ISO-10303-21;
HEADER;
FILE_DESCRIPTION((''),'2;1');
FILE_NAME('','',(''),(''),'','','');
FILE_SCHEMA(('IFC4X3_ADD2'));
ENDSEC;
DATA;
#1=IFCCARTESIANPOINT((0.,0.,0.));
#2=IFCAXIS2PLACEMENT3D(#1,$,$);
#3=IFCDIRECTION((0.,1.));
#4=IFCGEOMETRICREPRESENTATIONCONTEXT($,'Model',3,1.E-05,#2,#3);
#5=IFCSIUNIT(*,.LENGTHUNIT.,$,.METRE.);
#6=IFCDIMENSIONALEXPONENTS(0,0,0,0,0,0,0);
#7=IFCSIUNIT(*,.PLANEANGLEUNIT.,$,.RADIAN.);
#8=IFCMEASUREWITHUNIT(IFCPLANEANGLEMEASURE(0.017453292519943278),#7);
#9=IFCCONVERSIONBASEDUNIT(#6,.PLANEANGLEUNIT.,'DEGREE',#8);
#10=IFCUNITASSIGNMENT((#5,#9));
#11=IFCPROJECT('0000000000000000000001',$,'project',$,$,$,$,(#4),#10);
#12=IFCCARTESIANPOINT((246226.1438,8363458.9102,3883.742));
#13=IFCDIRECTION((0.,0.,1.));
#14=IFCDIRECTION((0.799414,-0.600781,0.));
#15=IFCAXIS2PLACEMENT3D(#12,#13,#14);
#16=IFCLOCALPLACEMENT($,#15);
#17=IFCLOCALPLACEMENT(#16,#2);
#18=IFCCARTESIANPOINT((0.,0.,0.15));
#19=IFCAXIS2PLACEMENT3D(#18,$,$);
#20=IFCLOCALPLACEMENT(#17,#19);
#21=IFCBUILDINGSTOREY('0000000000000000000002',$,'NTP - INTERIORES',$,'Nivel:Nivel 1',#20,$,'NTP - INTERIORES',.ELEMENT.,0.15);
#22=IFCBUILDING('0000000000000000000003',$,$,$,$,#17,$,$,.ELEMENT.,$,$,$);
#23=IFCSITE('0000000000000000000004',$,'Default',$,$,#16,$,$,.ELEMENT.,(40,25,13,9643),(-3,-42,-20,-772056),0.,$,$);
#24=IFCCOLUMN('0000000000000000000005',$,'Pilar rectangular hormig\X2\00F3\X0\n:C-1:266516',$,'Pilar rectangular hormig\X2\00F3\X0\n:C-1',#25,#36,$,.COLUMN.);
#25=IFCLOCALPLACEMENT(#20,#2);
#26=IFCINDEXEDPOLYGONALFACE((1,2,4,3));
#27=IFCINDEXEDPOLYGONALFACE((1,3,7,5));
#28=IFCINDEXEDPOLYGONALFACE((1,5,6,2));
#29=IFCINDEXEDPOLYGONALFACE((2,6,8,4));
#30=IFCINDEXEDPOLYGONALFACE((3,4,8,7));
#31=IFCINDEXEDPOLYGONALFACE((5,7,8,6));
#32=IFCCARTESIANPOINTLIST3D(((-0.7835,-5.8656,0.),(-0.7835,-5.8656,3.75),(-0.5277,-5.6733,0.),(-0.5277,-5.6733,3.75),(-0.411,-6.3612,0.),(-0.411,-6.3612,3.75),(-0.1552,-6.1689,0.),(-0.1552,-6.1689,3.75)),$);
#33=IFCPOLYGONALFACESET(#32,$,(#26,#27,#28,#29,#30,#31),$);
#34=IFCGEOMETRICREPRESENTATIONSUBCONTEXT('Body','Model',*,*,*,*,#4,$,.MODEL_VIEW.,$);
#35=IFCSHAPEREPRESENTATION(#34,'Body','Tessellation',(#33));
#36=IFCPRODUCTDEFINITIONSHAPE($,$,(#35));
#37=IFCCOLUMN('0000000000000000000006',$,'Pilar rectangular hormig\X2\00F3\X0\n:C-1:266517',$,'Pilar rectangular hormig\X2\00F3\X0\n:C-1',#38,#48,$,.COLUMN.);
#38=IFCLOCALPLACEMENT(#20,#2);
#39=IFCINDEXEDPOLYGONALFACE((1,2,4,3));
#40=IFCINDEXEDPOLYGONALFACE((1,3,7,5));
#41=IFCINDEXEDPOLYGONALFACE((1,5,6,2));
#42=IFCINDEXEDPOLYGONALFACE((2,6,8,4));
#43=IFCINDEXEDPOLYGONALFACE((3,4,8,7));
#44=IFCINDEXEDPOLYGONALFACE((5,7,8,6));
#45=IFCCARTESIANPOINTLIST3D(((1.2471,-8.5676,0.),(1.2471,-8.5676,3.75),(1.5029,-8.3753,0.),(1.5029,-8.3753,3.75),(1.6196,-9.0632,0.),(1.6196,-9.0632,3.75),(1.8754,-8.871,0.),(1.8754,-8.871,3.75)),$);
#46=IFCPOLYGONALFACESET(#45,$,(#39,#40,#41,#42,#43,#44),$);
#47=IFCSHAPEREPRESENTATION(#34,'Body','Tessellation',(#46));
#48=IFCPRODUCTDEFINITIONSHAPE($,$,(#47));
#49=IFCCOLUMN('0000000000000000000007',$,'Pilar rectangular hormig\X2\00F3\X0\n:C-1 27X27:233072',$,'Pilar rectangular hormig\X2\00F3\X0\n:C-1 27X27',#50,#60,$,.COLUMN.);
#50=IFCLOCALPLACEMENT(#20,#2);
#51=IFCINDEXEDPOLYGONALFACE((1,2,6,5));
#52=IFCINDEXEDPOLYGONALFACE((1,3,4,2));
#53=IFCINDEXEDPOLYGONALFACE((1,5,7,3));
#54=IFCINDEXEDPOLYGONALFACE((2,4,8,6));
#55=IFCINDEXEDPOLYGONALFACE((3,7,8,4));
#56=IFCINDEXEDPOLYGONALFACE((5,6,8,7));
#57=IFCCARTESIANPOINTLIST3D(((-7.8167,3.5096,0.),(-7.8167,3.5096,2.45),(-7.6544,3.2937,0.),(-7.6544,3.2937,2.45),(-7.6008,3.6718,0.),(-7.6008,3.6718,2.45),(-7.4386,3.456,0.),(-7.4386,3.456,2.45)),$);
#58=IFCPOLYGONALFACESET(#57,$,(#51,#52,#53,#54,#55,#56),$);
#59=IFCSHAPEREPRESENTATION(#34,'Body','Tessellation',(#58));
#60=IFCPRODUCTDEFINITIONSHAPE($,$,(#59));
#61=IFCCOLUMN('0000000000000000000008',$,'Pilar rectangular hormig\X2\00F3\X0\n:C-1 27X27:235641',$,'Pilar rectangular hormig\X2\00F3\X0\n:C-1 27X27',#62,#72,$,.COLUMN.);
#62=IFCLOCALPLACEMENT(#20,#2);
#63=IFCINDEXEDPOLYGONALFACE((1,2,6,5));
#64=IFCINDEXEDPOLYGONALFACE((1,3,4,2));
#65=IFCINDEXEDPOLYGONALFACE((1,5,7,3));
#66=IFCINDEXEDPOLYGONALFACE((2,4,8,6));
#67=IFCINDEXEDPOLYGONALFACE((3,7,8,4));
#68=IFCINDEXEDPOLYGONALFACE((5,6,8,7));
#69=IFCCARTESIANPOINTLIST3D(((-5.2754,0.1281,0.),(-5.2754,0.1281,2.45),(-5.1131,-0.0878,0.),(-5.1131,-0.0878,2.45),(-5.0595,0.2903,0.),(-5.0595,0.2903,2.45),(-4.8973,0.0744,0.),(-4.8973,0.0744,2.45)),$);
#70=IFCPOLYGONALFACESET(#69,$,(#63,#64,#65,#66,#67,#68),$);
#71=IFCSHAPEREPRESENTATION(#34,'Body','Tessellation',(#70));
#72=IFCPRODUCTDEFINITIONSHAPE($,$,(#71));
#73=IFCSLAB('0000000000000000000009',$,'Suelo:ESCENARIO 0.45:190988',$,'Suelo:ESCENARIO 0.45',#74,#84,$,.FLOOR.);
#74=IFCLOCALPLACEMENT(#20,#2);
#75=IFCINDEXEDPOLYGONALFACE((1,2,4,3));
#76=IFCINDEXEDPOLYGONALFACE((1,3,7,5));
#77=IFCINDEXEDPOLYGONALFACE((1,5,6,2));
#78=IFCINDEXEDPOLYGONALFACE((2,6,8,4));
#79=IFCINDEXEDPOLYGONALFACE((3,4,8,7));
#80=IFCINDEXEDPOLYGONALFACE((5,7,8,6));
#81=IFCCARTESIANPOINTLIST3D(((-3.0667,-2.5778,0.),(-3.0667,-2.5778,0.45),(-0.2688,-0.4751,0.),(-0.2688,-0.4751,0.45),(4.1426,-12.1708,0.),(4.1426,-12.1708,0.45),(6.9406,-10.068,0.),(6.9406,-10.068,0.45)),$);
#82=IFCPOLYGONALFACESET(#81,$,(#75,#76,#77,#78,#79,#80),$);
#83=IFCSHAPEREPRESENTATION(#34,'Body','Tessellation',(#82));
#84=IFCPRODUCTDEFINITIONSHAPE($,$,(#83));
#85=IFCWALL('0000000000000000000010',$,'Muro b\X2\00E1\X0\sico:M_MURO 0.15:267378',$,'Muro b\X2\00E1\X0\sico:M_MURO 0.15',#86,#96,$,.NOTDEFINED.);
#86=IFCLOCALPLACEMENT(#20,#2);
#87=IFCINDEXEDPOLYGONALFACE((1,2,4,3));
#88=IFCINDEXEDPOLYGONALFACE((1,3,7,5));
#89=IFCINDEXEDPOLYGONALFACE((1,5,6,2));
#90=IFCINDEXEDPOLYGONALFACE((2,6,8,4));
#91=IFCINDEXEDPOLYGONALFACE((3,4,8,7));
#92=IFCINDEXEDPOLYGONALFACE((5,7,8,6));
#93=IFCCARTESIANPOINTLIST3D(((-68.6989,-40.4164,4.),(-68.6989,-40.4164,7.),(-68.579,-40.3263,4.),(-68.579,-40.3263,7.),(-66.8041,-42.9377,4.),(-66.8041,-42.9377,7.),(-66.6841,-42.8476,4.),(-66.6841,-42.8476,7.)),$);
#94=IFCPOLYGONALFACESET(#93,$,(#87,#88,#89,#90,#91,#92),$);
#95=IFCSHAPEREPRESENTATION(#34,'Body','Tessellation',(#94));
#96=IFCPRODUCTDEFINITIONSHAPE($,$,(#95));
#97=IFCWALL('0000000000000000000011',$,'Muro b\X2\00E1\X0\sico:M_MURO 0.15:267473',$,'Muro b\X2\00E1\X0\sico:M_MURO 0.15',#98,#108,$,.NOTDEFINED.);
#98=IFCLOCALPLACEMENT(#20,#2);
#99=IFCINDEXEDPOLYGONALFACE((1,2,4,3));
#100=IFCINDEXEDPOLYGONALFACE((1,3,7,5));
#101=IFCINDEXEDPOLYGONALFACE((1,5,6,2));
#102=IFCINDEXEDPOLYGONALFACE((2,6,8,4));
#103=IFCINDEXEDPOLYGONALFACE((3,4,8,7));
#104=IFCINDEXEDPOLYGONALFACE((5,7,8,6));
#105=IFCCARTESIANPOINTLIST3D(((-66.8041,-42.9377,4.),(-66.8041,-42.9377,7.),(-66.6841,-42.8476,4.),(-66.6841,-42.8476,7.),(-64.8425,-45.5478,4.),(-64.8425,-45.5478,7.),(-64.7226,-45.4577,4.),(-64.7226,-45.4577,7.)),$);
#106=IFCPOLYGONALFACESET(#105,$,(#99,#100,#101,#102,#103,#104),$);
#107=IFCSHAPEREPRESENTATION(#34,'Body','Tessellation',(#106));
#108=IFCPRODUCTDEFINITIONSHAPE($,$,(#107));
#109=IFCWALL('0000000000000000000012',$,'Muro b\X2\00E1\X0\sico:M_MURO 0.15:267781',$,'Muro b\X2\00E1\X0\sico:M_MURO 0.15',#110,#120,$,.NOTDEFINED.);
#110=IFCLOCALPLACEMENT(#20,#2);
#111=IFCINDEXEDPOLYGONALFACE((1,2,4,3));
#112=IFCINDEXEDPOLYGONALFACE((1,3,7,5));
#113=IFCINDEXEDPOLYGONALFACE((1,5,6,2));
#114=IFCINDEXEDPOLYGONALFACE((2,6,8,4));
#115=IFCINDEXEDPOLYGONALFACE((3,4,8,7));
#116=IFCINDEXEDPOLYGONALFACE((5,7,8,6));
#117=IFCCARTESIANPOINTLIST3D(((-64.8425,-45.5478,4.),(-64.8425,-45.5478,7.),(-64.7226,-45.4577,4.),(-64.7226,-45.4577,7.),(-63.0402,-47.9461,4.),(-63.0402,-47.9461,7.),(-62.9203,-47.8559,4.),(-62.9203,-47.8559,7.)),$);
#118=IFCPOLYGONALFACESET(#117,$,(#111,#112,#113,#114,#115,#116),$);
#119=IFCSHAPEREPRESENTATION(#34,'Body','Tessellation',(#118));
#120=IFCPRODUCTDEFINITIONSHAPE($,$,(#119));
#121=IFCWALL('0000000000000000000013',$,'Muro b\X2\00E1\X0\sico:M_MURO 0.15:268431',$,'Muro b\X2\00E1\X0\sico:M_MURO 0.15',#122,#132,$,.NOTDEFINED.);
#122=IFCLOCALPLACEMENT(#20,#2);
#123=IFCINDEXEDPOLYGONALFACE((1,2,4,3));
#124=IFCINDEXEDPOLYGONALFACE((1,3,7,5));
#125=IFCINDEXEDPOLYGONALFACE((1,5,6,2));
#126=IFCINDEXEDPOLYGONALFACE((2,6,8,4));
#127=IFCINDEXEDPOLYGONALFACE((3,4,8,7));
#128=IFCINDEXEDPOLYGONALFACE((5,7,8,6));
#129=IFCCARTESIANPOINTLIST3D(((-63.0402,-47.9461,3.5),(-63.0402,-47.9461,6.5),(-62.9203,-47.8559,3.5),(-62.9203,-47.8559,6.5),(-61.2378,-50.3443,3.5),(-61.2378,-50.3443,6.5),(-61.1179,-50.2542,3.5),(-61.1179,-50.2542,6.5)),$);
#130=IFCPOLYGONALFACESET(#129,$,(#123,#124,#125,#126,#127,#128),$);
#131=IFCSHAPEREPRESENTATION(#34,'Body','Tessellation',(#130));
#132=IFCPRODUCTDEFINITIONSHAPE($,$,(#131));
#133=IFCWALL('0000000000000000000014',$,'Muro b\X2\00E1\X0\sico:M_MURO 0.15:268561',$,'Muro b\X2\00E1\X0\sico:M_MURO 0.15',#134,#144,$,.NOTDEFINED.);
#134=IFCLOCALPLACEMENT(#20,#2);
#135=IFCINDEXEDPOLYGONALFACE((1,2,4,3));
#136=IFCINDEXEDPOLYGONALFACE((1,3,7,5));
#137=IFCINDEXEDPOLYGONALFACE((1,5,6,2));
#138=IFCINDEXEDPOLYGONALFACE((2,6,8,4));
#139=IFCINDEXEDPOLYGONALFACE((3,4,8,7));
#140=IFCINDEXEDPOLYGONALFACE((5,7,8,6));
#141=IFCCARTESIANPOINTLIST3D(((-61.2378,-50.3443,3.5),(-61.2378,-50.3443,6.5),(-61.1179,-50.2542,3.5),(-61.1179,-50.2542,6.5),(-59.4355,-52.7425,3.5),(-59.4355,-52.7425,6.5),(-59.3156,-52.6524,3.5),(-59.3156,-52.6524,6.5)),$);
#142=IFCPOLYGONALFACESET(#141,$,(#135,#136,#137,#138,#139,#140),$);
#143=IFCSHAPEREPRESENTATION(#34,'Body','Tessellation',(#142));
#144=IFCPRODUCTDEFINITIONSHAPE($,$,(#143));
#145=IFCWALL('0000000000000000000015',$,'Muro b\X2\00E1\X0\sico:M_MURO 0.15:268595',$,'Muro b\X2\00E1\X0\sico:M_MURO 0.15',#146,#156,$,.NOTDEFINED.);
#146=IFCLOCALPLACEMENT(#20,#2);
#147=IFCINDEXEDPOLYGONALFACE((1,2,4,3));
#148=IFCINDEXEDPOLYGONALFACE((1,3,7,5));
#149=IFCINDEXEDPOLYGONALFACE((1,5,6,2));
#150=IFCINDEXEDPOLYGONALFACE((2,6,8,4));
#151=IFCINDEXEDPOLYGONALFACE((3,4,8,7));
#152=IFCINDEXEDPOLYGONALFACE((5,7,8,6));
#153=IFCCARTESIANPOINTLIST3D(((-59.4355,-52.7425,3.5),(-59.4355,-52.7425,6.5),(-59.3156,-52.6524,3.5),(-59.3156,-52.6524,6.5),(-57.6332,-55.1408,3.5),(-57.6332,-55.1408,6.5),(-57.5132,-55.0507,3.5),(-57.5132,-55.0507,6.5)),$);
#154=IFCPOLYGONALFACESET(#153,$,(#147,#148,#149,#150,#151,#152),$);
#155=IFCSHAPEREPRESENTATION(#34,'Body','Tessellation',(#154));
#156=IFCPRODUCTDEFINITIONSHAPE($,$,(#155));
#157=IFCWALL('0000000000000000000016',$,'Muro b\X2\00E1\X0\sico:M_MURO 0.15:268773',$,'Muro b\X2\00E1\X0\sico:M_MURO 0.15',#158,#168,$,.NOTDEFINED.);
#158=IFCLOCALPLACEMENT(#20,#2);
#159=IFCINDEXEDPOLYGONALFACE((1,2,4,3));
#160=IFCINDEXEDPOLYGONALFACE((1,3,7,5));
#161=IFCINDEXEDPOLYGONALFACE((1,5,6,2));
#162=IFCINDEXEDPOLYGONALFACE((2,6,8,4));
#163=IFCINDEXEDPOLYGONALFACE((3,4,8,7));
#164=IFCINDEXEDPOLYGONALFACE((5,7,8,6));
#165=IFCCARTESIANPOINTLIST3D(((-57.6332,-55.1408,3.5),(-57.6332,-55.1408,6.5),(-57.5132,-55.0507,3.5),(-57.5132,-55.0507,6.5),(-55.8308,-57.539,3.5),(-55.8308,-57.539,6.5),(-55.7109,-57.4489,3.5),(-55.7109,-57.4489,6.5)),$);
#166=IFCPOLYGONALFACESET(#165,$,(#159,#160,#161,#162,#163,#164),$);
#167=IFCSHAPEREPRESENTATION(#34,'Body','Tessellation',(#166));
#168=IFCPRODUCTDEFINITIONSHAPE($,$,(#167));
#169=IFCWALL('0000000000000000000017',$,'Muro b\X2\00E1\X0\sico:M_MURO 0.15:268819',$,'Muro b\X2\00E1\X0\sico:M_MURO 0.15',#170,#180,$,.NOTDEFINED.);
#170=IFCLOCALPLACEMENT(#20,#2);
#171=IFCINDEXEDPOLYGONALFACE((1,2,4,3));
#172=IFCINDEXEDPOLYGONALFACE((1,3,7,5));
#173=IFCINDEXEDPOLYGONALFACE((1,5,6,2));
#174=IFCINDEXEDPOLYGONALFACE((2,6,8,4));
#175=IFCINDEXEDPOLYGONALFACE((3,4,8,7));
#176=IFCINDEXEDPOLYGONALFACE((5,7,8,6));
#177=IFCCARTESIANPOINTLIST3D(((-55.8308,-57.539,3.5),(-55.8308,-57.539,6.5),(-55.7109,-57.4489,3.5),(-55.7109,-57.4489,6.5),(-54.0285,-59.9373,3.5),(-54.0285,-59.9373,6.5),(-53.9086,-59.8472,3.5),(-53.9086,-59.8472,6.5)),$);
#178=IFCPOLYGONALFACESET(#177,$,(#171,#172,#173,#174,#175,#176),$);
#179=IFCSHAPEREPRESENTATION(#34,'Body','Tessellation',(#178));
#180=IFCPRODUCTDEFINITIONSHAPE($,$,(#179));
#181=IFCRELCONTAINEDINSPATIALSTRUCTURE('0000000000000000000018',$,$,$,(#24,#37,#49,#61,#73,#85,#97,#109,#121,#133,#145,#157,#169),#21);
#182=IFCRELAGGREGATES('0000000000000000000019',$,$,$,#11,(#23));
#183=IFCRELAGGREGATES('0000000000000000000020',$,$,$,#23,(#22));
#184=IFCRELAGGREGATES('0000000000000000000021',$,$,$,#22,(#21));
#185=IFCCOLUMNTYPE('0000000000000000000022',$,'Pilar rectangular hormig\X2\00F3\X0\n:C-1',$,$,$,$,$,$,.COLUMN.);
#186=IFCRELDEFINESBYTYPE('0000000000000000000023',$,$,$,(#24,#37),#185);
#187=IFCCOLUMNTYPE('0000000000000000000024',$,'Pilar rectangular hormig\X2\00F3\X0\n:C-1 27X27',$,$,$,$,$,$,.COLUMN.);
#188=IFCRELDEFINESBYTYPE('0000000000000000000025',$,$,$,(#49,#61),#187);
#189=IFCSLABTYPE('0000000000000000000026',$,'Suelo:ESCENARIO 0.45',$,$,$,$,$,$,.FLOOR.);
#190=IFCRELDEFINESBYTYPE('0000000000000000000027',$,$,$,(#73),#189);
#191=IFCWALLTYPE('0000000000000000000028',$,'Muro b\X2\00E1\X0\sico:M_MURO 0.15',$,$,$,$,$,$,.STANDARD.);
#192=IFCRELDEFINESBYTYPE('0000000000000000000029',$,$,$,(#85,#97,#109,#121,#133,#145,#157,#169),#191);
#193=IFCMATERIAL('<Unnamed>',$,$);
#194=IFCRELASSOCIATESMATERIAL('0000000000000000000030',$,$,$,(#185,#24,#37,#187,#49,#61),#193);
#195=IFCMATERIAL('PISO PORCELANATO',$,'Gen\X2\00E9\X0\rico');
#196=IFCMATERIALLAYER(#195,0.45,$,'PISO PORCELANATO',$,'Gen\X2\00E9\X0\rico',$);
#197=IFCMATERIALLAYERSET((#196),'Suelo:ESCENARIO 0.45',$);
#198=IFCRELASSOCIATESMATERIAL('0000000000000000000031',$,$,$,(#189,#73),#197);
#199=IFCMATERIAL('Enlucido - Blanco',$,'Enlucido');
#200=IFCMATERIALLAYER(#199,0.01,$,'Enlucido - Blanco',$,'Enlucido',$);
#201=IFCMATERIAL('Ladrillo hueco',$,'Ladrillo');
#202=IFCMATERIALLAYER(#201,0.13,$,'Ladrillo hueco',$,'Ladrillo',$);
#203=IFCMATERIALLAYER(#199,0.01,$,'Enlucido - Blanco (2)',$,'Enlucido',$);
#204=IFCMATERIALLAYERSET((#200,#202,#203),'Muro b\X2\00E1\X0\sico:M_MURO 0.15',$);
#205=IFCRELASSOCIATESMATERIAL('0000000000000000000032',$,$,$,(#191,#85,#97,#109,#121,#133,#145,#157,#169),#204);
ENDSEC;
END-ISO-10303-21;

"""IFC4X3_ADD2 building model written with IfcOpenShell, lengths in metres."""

from ifc_helpers import new_model, entity, si_unit, converted_unit, direction, frame, frame_2d, origin, origin_2d_with_axis, place, context, subcontext, project, spatial, rectangle, extrude, source, transform, mapped, material, layer, layer_set, layer_usage, material_profile, profile_set, profile_usage, type_object, type_shapes, element, save


model = new_model("IFC4X3_ADD2")

# Units and contexts
model_context = context("Model", 3, precision=1e-05, world=origin(), true_north=direction((0.0, 1.0)))
body_context = subcontext(model_context, "Body", "Model", "MODEL_VIEW")
ifc_project = project(units=[si_unit("LENGTHUNIT", "METRE"), converted_unit("PLANEANGLEUNIT", "DEGREE", entity("IfcPlaneAngleMeasure", 0.017453292519943278), si_unit("PLANEANGLEUNIT", "RADIAN"), dimensions=[0, 0, 0, 0, 0, 0, 0])], contexts=[model_context])

# Site, building, storey
site_placement = place(None, frame((246226.1438, 8363458.9102, 3883.742), z_axis=(0.0, 0.0, 1.0), x_axis=(0.799414, -0.600781, 0.0)))
site = spatial("IfcSite", under=ifc_project, at=site_placement, Name="Default", CompositionType="ELEMENT", RefLatitude=(40, 25, 13, 9643), RefLongitude=(-3, -42, -20, -772056), RefElevation=0.0)
building_placement = place(site_placement, origin())
building = spatial("IfcBuilding", under=site, at=building_placement, CompositionType="ELEMENT")
storey_placement = place(building_placement, frame((0.0, 0.0, 0.15)))
storey = spatial("IfcBuildingStorey", under=building, at=storey_placement, Name="NTP - INTERIORES", ObjectType="Nivel:Nivel 1", LongName="NTP - INTERIORES", CompositionType="ELEMENT", Elevation=0.15)

# Columns
ifc_material_1 = material(Name="<Unnamed>")
ifc_material_profile_1 = material_profile(ifc_material_1, rectangle(XDim=0.32, YDim=0.62, at=origin_2d_with_axis()), Name="C-1")
ifc_profile_set_1 = profile_set([ifc_material_profile_1], Name="C-1")
ifc_profile_usage_1 = profile_usage(ifc_profile_set_1)
column_type_1 = type_object("IfcColumnType", Name="Pilar rectangular hormigón:C-1", PredefinedType="COLUMN", material=ifc_profile_set_1)
shared_shape_1 = source(origin(), body_context, "Body", "SweptSolid", [
    extrude(rectangle(XDim=0.32, YDim=0.62, at=origin_2d_with_axis()), frame((0.16, 0.31, 0.0), z_axis=(0.0, 0.0, 1.0), x_axis=(-1.0, 0.0, 0.0)), (0.0, 0.0, 1.0), 3.75),
])
type_shapes(column_type_1, [shared_shape_1])
for number, where, z_axis, x_axis, name in (
    (1, (-0.411, -6.3612, 0.0), (0.0, 0.0, 1.0), (0.799414, 0.60078, 0.0), "Pilar rectangular hormigón:C-1:266516"),
    (2, (1.6196, -9.0632, 0.0), (0.0, 0.0, 1.0), (0.799414, 0.60078, 0.0), "Pilar rectangular hormigón:C-1:266517"),
):
    element("IfcColumn", number, at=place(storey_placement, frame(where, z_axis=z_axis, x_axis=x_axis)), inside=storey, type_object=column_type_1, material=ifc_profile_usage_1, Name=name, ObjectType="Pilar rectangular hormigón:C-1", PredefinedType="COLUMN", context=body_context, shape_type="MappedRepresentation", body=[
        mapped(shared_shape_1, transform((0.0, 0.0, 0.0), scale=1.0)),
    ])
ifc_material_profile_2 = material_profile(ifc_material_1, rectangle(XDim=0.27, YDim=0.27, at=origin_2d_with_axis()), Name="C-1 27X27")
ifc_profile_set_2 = profile_set([ifc_material_profile_2], Name="C-1 27X27")
ifc_profile_usage_2 = profile_usage(ifc_profile_set_2)
column_type_2 = type_object("IfcColumnType", Name="Pilar rectangular hormigón:C-1 27X27", PredefinedType="COLUMN", material=ifc_profile_set_2)
shared_shape_2 = source(origin(), body_context, "Body", "SweptSolid", [
    extrude(rectangle(XDim=0.27, YDim=0.27, at=origin_2d_with_axis()), frame((0.135, 0.135, 0.0), z_axis=(0.0, 0.0, 1.0), x_axis=(-1.0, 0.0, 0.0)), (0.0, 0.0, 1.0), 2.45),
])
type_shapes(column_type_2, [shared_shape_2])
for number, where, z_axis, x_axis, name in (
    (3, (-7.6544, 3.2937, 0.0), (0.0, 0.0, 1.0), (0.799414, 0.60078, 0.0), "Pilar rectangular hormigón:C-1 27X27:233072"),
    (4, (-5.1131, -0.0878, 0.0), (0.0, 0.0, 1.0), (0.799414, 0.60078, 0.0), "Pilar rectangular hormigón:C-1 27X27:235641"),
):
    element("IfcColumn", number, at=place(storey_placement, frame(where, z_axis=z_axis, x_axis=x_axis)), inside=storey, type_object=column_type_2, material=ifc_profile_usage_2, Name=name, ObjectType="Pilar rectangular hormigón:C-1 27X27", PredefinedType="COLUMN", context=body_context, shape_type="MappedRepresentation", body=[
        mapped(shared_shape_2, transform((0.0, 0.0, 0.0), scale=1.0)),
    ])

# Slab
ifc_material_2 = material(Name="PISO PORCELANATO", Category="Genérico")
ifc_layer_1 = layer(ifc_material_2, 0.45, Name="PISO PORCELANATO", Category="Genérico")
ifc_layer_set_1 = layer_set([ifc_layer_1], Name="Suelo:ESCENARIO 0.45")
ifc_layer_usage_1 = layer_usage(ifc_layer_set_1, "AXIS3", "POSITIVE", 0.0)
slab_type_1 = type_object("IfcSlabType", Name="Suelo:ESCENARIO 0.45", PredefinedType="FLOOR", material=ifc_layer_set_1)
slab_1_placement = place(storey_placement, origin())
element("IfcSlab", 5, at=slab_1_placement, inside=storey, type_object=slab_type_1, material=ifc_layer_usage_1, Name="Suelo:ESCENARIO 0.45:190988", ObjectType="Suelo:ESCENARIO 0.45", PredefinedType="FLOOR", context=body_context, shape_type="SweptSolid", body=[
    extrude(rectangle(XDim=3.5, YDim=12.0, at=frame_2d((0.0, 0.0), x_axis=(1.0, 0.0))), frame((1.9369, -6.3229, 0.45), z_axis=(0.0, 0.0, -1.0), x_axis=(-0.799414, -0.60078, 0.0)), (0.0, 0.0, 1.0), 0.45),
])

# Walls
ifc_material_3 = material(Name="Enlucido - Blanco", Category="Enlucido")
ifc_layer_2 = layer(ifc_material_3, 0.01, Name="Enlucido - Blanco", Category="Enlucido")
ifc_material_4 = material(Name="Ladrillo hueco", Category="Ladrillo")
ifc_layer_3 = layer(ifc_material_4, 0.13, Name="Ladrillo hueco", Category="Ladrillo")
ifc_layer_4 = layer(ifc_material_3, 0.01, Name="Enlucido - Blanco (2)", Category="Enlucido")
ifc_layer_set_2 = layer_set([ifc_layer_2, ifc_layer_3, ifc_layer_4], Name="Muro básico:M_MURO 0.15")
wall_type = type_object("IfcWallType", Name="Muro básico:M_MURO 0.15", PredefinedType="STANDARD", material=ifc_layer_set_2)
wall_1_placement = place(storey_placement, frame((-68.639, -40.3713, 4.0), z_axis=(0.0, 0.0, 1.0), x_axis=(0.60078, -0.799414, 0.0)))
element("IfcWall", 6, at=wall_1_placement, inside=storey, type_object=wall_type, material=ifc_layer_set_2, Name="Muro básico:M_MURO 0.15:267378", ObjectType="Muro básico:M_MURO 0.15", PredefinedType="NOTDEFINED", context=body_context, shape_type="SweptSolid", body=[
    extrude(rectangle(XDim=3.154, YDim=0.15, at=frame_2d((1.577, 0.0), x_axis=(-1.0, 0.0))), origin(), (0.0, 0.0, 1.0), 3.0),
])
wall_2_placement = place(storey_placement, frame((-66.7441, -42.8927, 4.0), z_axis=(0.0, 0.0, 1.0), x_axis=(0.60078, -0.799414, 0.0)))
element("IfcWall", 7, at=wall_2_placement, inside=storey, type_object=wall_type, material=ifc_layer_set_2, Name="Muro básico:M_MURO 0.15:267473", ObjectType="Muro básico:M_MURO 0.15", PredefinedType="NOTDEFINED", context=body_context, shape_type="SweptSolid", body=[
    extrude(rectangle(XDim=3.265, YDim=0.15, at=frame_2d((1.6325, 0.0), x_axis=(-1.0, 0.0))), origin(), (0.0, 0.0, 1.0), 3.0),
])
wall_3_placement = place(storey_placement, frame((-64.7826, -45.5028, 4.0), z_axis=(0.0, 0.0, 1.0), x_axis=(0.60078, -0.799414, 0.0)))
element("IfcWall", 8, at=wall_3_placement, inside=storey, type_object=wall_type, material=ifc_layer_set_2, Name="Muro básico:M_MURO 0.15:267781", ObjectType="Muro básico:M_MURO 0.15", PredefinedType="NOTDEFINED", context=body_context, shape_type="SweptSolid", body=[
    extrude(rectangle(XDim=3.0, YDim=0.15, at=frame_2d((1.5, 0.0), x_axis=(-1.0, 0.0))), origin(), (0.0, 0.0, 1.0), 3.0),
])
wall_4_placement = place(storey_placement, frame((-62.9802, -47.901, 3.5), z_axis=(0.0, 0.0, 1.0), x_axis=(0.60078, -0.799414, 0.0)))
element("IfcWall", 9, at=wall_4_placement, inside=storey, type_object=wall_type, material=ifc_layer_set_2, Name="Muro básico:M_MURO 0.15:268431", ObjectType="Muro básico:M_MURO 0.15", PredefinedType="NOTDEFINED", context=body_context, shape_type="SweptSolid", body=[
    extrude(rectangle(XDim=3.0, YDim=0.15, at=frame_2d((1.5, 0.0), x_axis=(-1.0, 0.0))), origin(), (0.0, 0.0, 1.0), 3.0),
])
wall_5_placement = place(storey_placement, frame((-61.1779, -50.2992, 3.5), z_axis=(0.0, 0.0, 1.0), x_axis=(0.60078, -0.799414, 0.0)))
element("IfcWall", 10, at=wall_5_placement, inside=storey, type_object=wall_type, material=ifc_layer_set_2, Name="Muro básico:M_MURO 0.15:268561", ObjectType="Muro básico:M_MURO 0.15", PredefinedType="NOTDEFINED", context=body_context, shape_type="SweptSolid", body=[
    extrude(rectangle(XDim=3.0, YDim=0.15, at=frame_2d((1.5, 0.0), x_axis=(-1.0, 0.0))), origin(), (0.0, 0.0, 1.0), 3.0),
])
wall_6_placement = place(storey_placement, frame((-59.3755, -52.6975, 3.5), z_axis=(0.0, 0.0, 1.0), x_axis=(0.60078, -0.799414, 0.0)))
element("IfcWall", 11, at=wall_6_placement, inside=storey, type_object=wall_type, material=ifc_layer_set_2, Name="Muro básico:M_MURO 0.15:268595", ObjectType="Muro básico:M_MURO 0.15", PredefinedType="NOTDEFINED", context=body_context, shape_type="SweptSolid", body=[
    extrude(rectangle(XDim=3.0, YDim=0.15, at=frame_2d((1.5, 0.0), x_axis=(-1.0, 0.0))), origin(), (0.0, 0.0, 1.0), 3.0),
])
wall_7_placement = place(storey_placement, frame((-57.5732, -55.0957, 3.5), z_axis=(0.0, 0.0, 1.0), x_axis=(0.60078, -0.799414, 0.0)))
element("IfcWall", 12, at=wall_7_placement, inside=storey, type_object=wall_type, material=ifc_layer_set_2, Name="Muro básico:M_MURO 0.15:268773", ObjectType="Muro básico:M_MURO 0.15", PredefinedType="NOTDEFINED", context=body_context, shape_type="SweptSolid", body=[
    extrude(rectangle(XDim=3.0, YDim=0.15, at=frame_2d((1.5, 0.0), x_axis=(-1.0, 0.0))), origin(), (0.0, 0.0, 1.0), 3.0),
])
wall_8_placement = place(storey_placement, frame((-55.7709, -57.494, 3.5), z_axis=(0.0, 0.0, 1.0), x_axis=(0.60078, -0.799414, 0.0)))
element("IfcWall", 13, at=wall_8_placement, inside=storey, type_object=wall_type, material=ifc_layer_set_2, Name="Muro básico:M_MURO 0.15:268819", ObjectType="Muro básico:M_MURO 0.15", PredefinedType="NOTDEFINED", context=body_context, shape_type="SweptSolid", body=[
    extrude(rectangle(XDim=3.0, YDim=0.15, at=frame_2d((1.5, 0.0), x_axis=(-1.0, 0.0))), origin(), (0.0, 0.0, 1.0), 3.0),
])

save(model, "model.ifc")
